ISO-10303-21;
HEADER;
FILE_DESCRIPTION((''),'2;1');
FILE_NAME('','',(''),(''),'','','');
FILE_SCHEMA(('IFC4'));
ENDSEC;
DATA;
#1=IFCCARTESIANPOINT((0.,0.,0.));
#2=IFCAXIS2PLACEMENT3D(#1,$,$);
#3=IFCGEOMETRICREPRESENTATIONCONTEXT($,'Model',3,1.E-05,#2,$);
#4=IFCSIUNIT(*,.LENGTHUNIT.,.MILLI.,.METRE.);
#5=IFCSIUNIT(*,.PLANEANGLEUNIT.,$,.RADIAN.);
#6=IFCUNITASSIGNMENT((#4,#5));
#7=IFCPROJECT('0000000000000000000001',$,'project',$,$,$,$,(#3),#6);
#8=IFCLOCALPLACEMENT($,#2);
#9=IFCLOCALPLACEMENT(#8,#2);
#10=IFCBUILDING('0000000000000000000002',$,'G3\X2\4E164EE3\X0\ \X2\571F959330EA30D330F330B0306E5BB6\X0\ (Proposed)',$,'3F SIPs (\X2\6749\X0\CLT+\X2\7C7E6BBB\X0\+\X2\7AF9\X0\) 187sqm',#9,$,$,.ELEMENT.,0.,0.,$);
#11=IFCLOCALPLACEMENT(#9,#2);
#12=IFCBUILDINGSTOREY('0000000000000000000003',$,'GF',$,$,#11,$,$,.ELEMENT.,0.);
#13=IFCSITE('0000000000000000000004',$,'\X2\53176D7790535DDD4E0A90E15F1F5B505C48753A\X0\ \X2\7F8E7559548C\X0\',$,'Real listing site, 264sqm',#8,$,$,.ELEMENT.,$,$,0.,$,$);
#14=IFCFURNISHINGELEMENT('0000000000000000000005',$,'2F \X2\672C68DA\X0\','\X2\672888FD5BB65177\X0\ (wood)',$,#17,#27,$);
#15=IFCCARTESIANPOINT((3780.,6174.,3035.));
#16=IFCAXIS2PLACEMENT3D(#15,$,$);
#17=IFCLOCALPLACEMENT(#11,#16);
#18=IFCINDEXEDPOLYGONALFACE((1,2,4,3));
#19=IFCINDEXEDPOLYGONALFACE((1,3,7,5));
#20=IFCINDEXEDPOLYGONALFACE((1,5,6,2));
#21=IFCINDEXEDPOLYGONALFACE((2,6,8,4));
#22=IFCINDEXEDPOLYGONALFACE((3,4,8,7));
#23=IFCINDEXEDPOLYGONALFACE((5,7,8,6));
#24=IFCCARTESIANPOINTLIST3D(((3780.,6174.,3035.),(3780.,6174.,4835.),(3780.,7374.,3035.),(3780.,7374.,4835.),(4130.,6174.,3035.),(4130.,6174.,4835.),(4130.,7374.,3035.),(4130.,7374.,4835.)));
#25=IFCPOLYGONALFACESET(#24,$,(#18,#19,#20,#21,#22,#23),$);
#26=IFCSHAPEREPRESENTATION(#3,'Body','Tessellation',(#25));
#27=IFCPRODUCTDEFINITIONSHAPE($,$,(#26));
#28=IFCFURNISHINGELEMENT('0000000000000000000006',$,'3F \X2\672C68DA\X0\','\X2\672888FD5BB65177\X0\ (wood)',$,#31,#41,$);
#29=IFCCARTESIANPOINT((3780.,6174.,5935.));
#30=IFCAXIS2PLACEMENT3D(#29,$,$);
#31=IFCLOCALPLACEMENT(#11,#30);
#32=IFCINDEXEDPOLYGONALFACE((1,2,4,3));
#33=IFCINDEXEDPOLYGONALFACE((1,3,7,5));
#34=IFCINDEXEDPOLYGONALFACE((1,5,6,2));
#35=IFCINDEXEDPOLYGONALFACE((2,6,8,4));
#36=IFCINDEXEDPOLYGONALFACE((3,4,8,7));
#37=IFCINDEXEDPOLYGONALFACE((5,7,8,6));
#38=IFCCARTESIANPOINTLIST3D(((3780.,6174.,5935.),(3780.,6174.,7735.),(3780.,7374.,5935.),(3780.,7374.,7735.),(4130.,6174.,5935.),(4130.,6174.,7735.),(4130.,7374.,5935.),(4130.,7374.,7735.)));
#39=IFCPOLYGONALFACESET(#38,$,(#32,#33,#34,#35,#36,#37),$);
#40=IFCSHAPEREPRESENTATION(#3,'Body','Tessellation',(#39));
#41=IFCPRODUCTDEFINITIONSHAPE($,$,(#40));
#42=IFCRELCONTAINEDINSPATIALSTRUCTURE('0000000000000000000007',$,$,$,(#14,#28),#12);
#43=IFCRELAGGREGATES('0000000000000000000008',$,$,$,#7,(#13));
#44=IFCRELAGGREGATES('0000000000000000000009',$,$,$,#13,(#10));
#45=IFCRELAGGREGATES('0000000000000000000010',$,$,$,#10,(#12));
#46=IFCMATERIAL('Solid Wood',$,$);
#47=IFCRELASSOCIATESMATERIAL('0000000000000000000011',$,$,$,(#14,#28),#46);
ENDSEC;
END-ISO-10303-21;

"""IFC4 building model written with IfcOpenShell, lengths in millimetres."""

from ifc_helpers import new_model, si_unit, frame, frame_2d, origin, place, context, project, spatial, rectangle, extrude, material, element, save


model = new_model("IFC4")

# Units and contexts
model_context = context("Model", 3, precision=1e-05, world=origin())
ifc_project = project(units=[si_unit("LENGTHUNIT", "METRE", prefix="MILLI"), si_unit("PLANEANGLEUNIT", "RADIAN")], contexts=[model_context])

# Site, building, storey
site_placement = place(None, origin())
site = spatial("IfcSite", under=ifc_project, at=site_placement, Name="北海道川上郡弟子屈町 美留和", ObjectType="Real listing site, 264sqm", CompositionType="ELEMENT", RefElevation=0.0)
building_placement = place(site_placement, origin())
building = spatial("IfcBuilding", under=site, at=building_placement, Name="G3世代 土間リビングの家 (Proposed)", ObjectType="3F SIPs (杉CLT+籾殻+竹) 187sqm", CompositionType="ELEMENT", ElevationOfRefHeight=0.0, ElevationOfTerrain=0.0)
storey_placement = place(building_placement, origin())
storey = spatial("IfcBuildingStorey", under=building, at=storey_placement, Name="GF", CompositionType="ELEMENT", Elevation=0.0)

# Shared definitions
ifc_material_1 = material(Name="Solid Wood")

# Furnishing elements
furnishing_1_placement = place(storey_placement, frame((3780.0, 6174.0, 3035.0)))
element("IfcFurnishingElement", 1, at=furnishing_1_placement, inside=storey, material=ifc_material_1, Name="2F 本棚", Description="木製家具 (wood)", context=model_context, shape_type="SweptSolid", body=[
    extrude(rectangle(XDim=350.0, YDim=1200.0, at=frame_2d((175.0, 600.0))), frame((3780.0, 6174.0, 3035.0)), (0.0, 0.0, 1.0), 1800.0),
])
furnishing_2_placement = place(storey_placement, frame((3780.0, 6174.0, 5935.0)))
element("IfcFurnishingElement", 2, at=furnishing_2_placement, inside=storey, material=ifc_material_1, Name="3F 本棚", Description="木製家具 (wood)", context=model_context, shape_type="SweptSolid", body=[
    extrude(rectangle(XDim=350.0, YDim=1200.0, at=frame_2d((175.0, 600.0))), frame((3780.0, 6174.0, 5935.0)), (0.0, 0.0, 1.0), 1800.0),
])

save(model, "model.ifc")
